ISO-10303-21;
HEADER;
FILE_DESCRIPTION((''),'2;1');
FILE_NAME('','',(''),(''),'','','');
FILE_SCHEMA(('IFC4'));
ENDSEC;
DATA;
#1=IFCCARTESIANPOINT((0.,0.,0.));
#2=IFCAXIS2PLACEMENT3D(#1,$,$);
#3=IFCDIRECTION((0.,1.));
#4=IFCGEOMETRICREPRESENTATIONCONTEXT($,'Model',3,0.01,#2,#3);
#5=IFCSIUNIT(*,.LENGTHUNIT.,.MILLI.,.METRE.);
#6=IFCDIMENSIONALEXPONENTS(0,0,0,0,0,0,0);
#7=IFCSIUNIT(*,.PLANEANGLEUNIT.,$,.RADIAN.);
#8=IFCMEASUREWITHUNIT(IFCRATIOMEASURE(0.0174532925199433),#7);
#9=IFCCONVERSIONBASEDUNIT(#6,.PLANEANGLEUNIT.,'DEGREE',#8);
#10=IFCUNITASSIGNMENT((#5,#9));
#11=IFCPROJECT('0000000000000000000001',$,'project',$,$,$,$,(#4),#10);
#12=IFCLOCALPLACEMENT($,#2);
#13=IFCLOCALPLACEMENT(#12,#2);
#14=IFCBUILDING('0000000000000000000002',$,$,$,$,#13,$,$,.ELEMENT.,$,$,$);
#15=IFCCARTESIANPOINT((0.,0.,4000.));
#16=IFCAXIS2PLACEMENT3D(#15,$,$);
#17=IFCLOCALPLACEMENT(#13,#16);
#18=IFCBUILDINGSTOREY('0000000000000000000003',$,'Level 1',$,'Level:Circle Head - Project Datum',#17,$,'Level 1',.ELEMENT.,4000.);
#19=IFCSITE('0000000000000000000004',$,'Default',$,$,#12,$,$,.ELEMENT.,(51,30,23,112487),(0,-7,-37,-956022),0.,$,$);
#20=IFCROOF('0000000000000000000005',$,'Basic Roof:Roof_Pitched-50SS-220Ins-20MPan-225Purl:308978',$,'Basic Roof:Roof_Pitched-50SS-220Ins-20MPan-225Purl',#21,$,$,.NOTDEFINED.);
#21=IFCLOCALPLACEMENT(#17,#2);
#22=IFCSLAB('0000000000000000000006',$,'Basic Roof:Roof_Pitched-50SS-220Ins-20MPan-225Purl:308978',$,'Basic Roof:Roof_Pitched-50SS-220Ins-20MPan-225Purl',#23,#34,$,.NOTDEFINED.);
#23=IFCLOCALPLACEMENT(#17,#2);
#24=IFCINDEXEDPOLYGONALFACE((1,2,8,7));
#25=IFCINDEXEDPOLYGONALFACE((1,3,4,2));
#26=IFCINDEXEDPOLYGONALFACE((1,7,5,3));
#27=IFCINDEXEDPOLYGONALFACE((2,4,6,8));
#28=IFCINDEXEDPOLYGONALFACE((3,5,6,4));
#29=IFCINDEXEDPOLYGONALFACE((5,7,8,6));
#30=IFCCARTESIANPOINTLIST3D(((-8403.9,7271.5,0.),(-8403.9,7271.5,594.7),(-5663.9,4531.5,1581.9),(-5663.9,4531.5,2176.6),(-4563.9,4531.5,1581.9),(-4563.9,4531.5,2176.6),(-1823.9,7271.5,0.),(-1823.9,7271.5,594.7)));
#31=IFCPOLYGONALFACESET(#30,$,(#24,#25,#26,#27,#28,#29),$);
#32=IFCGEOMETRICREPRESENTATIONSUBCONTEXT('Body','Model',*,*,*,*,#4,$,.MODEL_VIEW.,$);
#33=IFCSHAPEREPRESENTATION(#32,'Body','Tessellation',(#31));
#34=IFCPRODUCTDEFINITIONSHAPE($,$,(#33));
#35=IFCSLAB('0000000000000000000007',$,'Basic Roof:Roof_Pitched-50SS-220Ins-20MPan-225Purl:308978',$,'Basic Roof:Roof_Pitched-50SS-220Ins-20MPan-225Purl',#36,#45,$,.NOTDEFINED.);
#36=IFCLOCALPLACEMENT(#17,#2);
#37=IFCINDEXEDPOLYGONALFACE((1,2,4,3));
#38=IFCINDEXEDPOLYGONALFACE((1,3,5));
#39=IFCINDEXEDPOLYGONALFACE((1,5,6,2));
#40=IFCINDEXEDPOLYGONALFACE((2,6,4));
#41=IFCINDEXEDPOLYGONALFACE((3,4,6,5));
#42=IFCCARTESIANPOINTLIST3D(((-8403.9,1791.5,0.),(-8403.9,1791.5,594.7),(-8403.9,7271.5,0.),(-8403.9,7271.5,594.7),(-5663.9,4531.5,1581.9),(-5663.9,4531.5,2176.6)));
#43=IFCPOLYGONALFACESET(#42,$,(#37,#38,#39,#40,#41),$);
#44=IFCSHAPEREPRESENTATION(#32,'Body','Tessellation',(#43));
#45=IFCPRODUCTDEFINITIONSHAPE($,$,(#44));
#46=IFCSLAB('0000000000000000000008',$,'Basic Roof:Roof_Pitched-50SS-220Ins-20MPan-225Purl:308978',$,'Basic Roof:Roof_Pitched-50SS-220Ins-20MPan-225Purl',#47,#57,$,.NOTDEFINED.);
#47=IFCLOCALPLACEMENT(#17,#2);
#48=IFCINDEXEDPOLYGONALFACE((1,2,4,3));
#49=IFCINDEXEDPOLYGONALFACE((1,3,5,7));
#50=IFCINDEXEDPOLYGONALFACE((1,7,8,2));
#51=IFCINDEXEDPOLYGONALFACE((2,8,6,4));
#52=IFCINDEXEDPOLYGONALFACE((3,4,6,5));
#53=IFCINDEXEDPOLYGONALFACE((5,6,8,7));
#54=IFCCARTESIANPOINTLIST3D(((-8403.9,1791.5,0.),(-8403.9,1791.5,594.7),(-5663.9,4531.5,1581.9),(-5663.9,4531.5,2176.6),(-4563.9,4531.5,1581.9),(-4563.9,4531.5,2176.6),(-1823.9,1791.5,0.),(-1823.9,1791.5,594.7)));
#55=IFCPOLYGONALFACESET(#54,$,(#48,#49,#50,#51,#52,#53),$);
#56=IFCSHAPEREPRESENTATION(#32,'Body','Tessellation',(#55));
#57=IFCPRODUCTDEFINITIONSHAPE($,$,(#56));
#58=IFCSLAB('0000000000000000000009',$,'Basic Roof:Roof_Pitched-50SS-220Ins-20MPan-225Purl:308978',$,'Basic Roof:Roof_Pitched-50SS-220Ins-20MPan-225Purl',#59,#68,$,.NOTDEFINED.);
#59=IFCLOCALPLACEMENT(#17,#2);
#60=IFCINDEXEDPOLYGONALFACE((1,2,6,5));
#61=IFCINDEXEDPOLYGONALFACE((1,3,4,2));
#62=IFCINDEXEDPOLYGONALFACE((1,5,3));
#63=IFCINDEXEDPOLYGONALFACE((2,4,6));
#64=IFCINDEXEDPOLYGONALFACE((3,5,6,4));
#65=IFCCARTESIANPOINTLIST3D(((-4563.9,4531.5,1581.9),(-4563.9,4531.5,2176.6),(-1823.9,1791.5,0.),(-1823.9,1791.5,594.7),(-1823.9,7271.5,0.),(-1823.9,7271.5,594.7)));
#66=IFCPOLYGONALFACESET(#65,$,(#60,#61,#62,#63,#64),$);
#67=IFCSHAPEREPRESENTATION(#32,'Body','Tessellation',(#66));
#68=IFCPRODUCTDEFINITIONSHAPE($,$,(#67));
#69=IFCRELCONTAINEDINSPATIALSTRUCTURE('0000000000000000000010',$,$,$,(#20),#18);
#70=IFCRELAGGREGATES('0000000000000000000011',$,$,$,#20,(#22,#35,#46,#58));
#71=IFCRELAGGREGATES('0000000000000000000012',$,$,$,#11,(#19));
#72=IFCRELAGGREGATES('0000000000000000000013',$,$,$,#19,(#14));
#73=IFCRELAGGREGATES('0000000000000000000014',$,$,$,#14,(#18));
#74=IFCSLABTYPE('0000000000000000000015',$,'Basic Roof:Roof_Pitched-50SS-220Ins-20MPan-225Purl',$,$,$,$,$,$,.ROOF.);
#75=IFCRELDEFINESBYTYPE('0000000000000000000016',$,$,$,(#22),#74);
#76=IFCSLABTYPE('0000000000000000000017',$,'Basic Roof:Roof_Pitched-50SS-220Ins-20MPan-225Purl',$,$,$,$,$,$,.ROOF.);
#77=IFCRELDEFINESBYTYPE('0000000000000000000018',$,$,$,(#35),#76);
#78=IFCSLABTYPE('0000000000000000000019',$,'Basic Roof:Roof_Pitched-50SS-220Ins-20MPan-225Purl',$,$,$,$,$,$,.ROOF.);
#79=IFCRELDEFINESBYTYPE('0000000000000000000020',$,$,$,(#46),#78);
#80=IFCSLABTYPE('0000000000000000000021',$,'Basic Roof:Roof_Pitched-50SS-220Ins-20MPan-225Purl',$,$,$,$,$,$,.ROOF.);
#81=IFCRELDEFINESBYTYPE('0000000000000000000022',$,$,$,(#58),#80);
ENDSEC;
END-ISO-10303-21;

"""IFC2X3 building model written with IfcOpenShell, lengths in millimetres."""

from ifc_helpers import new_model, entity, si_unit, converted_unit, direction, frame, origin, place, context, subcontext, project, spatial, polyline, outline, extrude, type_object, element, aggregate, save


model = new_model("IFC2X3")

# Units and contexts
model_context = context("Model", 3, precision=0.01, world=origin(), true_north=direction((0.0, 1.0)))
body_context = subcontext(model_context, "Body", "Model", "MODEL_VIEW")
ifc_project = project(units=[si_unit("LENGTHUNIT", "METRE", prefix="MILLI"), converted_unit("PLANEANGLEUNIT", "DEGREE", entity("IfcRatioMeasure", 0.0174532925199433), si_unit("PLANEANGLEUNIT", "RADIAN"), dimensions=[0, 0, 0, 0, 0, 0, 0])], contexts=[model_context])

# Site, building, storey
site_placement = place(None, origin())
site = spatial("IfcSite", under=ifc_project, at=site_placement, Name="Default", CompositionType="ELEMENT", RefLatitude=(51, 30, 23, 112487), RefLongitude=(0, -7, -37, -956022), RefElevation=0.0)
building_placement = place(site_placement, origin())
building = spatial("IfcBuilding", under=site, at=building_placement, CompositionType="ELEMENT")
storey_placement = place(building_placement, frame((0.0, 0.0, 4000.0)))
storey = spatial("IfcBuildingStorey", under=building, at=storey_placement, Name="Level 1", ObjectType="Level:Circle Head - Project Datum", LongName="Level 1", CompositionType="ELEMENT", Elevation=4000.0)

# Roof, slabs
roof_placement = place(storey_placement, frame((-8403.9, 1791.5, 0.0)))
roof = element("IfcRoof", 1, at=roof_placement, inside=storey, Name="Basic Roof:Roof_Pitched-50SS-220Ins-20MPan-225Purl:308978", ObjectType="Basic Roof:Roof_Pitched-50SS-220Ins-20MPan-225Purl", ShapeType="NOTDEFINED")
slab_type_1 = type_object("IfcSlabType", Name="Basic Roof:Roof_Pitched-50SS-220Ins-20MPan-225Purl", PredefinedType="ROOF")
slab_1_placement = place(roof_placement, origin())
slab_1 = element("IfcSlab", 2, at=slab_1_placement, type_object=slab_type_1, Name="Basic Roof:Roof_Pitched-50SS-220Ins-20MPan-225Purl:308978", ObjectType="Basic Roof:Roof_Pitched-50SS-220Ins-20MPan-225Purl", PredefinedType="NOTDEFINED", context=body_context, shape_type="SweptSolid", body=[
    extrude(outline(polyline([(3290.0, 1581.9), (-3290.0, 1581.9), (-550.0, -1581.9), (550.0, -1581.9), (3290.0, 1581.9)])), frame((3290.0, 4110.0, 791.0), z_axis=(0.0, 0.5, 0.866025), x_axis=(1.0, 0.0, 0.0)), (0.0, -0.5, 0.866025), 594.7),
])
slab_type_2 = type_object("IfcSlabType", Name="Basic Roof:Roof_Pitched-50SS-220Ins-20MPan-225Purl", PredefinedType="ROOF")
slab_2_placement = place(roof_placement, origin())
slab_2 = element("IfcSlab", 3, at=slab_2_placement, type_object=slab_type_2, Name="Basic Roof:Roof_Pitched-50SS-220Ins-20MPan-225Purl:308978", ObjectType="Basic Roof:Roof_Pitched-50SS-220Ins-20MPan-225Purl", PredefinedType="NOTDEFINED", context=body_context, shape_type="SweptSolid", body=[
    extrude(outline(polyline([(-1581.9, 2740.0), (-1581.9, -2740.0), (1581.9, 0.0), (-1581.9, 2740.0)])), frame((1370.0, 2740.0, 791.0), z_axis=(-0.5, 0.0, 0.866025), x_axis=(0.866025, 0.0, 0.5)), (0.5, 0.0, 0.866025), 594.7),
])
slab_type_3 = type_object("IfcSlabType", Name="Basic Roof:Roof_Pitched-50SS-220Ins-20MPan-225Purl", PredefinedType="ROOF")
slab_3_placement = place(roof_placement, origin())
slab_3 = element("IfcSlab", 4, at=slab_3_placement, type_object=slab_type_3, Name="Basic Roof:Roof_Pitched-50SS-220Ins-20MPan-225Purl:308978", ObjectType="Basic Roof:Roof_Pitched-50SS-220Ins-20MPan-225Purl", PredefinedType="NOTDEFINED", context=body_context, shape_type="SweptSolid", body=[
    extrude(outline(polyline([(-3290.0, -1581.9), (3290.0, -1581.9), (550.0, 1581.9), (-550.0, 1581.9), (-3290.0, -1581.9)])), frame((3290.0, 1370.0, 791.0), z_axis=(0.0, -0.5, 0.866025), x_axis=(1.0, 0.0, 0.0)), (0.0, 0.5, 0.866025), 594.7),
])
slab_type_4 = type_object("IfcSlabType", Name="Basic Roof:Roof_Pitched-50SS-220Ins-20MPan-225Purl", PredefinedType="ROOF")
slab_4_placement = place(roof_placement, origin())
slab_4 = element("IfcSlab", 5, at=slab_4_placement, type_object=slab_type_4, Name="Basic Roof:Roof_Pitched-50SS-220Ins-20MPan-225Purl:308978", ObjectType="Basic Roof:Roof_Pitched-50SS-220Ins-20MPan-225Purl", PredefinedType="NOTDEFINED", context=body_context, shape_type="SweptSolid", body=[
    extrude(outline(polyline([(-1581.9, 0.0), (1581.9, -2740.0), (1581.9, 2740.0), (-1581.9, 0.0)])), frame((5210.0, 2740.0, 791.0), z_axis=(0.5, 0.0, 0.866025), x_axis=(0.866025, 0.0, -0.5)), (-0.5, 0.0, 0.866025), 594.7),
])
aggregate(roof, [slab_1, slab_2, slab_3, slab_4])

save(model, "model.ifc")
